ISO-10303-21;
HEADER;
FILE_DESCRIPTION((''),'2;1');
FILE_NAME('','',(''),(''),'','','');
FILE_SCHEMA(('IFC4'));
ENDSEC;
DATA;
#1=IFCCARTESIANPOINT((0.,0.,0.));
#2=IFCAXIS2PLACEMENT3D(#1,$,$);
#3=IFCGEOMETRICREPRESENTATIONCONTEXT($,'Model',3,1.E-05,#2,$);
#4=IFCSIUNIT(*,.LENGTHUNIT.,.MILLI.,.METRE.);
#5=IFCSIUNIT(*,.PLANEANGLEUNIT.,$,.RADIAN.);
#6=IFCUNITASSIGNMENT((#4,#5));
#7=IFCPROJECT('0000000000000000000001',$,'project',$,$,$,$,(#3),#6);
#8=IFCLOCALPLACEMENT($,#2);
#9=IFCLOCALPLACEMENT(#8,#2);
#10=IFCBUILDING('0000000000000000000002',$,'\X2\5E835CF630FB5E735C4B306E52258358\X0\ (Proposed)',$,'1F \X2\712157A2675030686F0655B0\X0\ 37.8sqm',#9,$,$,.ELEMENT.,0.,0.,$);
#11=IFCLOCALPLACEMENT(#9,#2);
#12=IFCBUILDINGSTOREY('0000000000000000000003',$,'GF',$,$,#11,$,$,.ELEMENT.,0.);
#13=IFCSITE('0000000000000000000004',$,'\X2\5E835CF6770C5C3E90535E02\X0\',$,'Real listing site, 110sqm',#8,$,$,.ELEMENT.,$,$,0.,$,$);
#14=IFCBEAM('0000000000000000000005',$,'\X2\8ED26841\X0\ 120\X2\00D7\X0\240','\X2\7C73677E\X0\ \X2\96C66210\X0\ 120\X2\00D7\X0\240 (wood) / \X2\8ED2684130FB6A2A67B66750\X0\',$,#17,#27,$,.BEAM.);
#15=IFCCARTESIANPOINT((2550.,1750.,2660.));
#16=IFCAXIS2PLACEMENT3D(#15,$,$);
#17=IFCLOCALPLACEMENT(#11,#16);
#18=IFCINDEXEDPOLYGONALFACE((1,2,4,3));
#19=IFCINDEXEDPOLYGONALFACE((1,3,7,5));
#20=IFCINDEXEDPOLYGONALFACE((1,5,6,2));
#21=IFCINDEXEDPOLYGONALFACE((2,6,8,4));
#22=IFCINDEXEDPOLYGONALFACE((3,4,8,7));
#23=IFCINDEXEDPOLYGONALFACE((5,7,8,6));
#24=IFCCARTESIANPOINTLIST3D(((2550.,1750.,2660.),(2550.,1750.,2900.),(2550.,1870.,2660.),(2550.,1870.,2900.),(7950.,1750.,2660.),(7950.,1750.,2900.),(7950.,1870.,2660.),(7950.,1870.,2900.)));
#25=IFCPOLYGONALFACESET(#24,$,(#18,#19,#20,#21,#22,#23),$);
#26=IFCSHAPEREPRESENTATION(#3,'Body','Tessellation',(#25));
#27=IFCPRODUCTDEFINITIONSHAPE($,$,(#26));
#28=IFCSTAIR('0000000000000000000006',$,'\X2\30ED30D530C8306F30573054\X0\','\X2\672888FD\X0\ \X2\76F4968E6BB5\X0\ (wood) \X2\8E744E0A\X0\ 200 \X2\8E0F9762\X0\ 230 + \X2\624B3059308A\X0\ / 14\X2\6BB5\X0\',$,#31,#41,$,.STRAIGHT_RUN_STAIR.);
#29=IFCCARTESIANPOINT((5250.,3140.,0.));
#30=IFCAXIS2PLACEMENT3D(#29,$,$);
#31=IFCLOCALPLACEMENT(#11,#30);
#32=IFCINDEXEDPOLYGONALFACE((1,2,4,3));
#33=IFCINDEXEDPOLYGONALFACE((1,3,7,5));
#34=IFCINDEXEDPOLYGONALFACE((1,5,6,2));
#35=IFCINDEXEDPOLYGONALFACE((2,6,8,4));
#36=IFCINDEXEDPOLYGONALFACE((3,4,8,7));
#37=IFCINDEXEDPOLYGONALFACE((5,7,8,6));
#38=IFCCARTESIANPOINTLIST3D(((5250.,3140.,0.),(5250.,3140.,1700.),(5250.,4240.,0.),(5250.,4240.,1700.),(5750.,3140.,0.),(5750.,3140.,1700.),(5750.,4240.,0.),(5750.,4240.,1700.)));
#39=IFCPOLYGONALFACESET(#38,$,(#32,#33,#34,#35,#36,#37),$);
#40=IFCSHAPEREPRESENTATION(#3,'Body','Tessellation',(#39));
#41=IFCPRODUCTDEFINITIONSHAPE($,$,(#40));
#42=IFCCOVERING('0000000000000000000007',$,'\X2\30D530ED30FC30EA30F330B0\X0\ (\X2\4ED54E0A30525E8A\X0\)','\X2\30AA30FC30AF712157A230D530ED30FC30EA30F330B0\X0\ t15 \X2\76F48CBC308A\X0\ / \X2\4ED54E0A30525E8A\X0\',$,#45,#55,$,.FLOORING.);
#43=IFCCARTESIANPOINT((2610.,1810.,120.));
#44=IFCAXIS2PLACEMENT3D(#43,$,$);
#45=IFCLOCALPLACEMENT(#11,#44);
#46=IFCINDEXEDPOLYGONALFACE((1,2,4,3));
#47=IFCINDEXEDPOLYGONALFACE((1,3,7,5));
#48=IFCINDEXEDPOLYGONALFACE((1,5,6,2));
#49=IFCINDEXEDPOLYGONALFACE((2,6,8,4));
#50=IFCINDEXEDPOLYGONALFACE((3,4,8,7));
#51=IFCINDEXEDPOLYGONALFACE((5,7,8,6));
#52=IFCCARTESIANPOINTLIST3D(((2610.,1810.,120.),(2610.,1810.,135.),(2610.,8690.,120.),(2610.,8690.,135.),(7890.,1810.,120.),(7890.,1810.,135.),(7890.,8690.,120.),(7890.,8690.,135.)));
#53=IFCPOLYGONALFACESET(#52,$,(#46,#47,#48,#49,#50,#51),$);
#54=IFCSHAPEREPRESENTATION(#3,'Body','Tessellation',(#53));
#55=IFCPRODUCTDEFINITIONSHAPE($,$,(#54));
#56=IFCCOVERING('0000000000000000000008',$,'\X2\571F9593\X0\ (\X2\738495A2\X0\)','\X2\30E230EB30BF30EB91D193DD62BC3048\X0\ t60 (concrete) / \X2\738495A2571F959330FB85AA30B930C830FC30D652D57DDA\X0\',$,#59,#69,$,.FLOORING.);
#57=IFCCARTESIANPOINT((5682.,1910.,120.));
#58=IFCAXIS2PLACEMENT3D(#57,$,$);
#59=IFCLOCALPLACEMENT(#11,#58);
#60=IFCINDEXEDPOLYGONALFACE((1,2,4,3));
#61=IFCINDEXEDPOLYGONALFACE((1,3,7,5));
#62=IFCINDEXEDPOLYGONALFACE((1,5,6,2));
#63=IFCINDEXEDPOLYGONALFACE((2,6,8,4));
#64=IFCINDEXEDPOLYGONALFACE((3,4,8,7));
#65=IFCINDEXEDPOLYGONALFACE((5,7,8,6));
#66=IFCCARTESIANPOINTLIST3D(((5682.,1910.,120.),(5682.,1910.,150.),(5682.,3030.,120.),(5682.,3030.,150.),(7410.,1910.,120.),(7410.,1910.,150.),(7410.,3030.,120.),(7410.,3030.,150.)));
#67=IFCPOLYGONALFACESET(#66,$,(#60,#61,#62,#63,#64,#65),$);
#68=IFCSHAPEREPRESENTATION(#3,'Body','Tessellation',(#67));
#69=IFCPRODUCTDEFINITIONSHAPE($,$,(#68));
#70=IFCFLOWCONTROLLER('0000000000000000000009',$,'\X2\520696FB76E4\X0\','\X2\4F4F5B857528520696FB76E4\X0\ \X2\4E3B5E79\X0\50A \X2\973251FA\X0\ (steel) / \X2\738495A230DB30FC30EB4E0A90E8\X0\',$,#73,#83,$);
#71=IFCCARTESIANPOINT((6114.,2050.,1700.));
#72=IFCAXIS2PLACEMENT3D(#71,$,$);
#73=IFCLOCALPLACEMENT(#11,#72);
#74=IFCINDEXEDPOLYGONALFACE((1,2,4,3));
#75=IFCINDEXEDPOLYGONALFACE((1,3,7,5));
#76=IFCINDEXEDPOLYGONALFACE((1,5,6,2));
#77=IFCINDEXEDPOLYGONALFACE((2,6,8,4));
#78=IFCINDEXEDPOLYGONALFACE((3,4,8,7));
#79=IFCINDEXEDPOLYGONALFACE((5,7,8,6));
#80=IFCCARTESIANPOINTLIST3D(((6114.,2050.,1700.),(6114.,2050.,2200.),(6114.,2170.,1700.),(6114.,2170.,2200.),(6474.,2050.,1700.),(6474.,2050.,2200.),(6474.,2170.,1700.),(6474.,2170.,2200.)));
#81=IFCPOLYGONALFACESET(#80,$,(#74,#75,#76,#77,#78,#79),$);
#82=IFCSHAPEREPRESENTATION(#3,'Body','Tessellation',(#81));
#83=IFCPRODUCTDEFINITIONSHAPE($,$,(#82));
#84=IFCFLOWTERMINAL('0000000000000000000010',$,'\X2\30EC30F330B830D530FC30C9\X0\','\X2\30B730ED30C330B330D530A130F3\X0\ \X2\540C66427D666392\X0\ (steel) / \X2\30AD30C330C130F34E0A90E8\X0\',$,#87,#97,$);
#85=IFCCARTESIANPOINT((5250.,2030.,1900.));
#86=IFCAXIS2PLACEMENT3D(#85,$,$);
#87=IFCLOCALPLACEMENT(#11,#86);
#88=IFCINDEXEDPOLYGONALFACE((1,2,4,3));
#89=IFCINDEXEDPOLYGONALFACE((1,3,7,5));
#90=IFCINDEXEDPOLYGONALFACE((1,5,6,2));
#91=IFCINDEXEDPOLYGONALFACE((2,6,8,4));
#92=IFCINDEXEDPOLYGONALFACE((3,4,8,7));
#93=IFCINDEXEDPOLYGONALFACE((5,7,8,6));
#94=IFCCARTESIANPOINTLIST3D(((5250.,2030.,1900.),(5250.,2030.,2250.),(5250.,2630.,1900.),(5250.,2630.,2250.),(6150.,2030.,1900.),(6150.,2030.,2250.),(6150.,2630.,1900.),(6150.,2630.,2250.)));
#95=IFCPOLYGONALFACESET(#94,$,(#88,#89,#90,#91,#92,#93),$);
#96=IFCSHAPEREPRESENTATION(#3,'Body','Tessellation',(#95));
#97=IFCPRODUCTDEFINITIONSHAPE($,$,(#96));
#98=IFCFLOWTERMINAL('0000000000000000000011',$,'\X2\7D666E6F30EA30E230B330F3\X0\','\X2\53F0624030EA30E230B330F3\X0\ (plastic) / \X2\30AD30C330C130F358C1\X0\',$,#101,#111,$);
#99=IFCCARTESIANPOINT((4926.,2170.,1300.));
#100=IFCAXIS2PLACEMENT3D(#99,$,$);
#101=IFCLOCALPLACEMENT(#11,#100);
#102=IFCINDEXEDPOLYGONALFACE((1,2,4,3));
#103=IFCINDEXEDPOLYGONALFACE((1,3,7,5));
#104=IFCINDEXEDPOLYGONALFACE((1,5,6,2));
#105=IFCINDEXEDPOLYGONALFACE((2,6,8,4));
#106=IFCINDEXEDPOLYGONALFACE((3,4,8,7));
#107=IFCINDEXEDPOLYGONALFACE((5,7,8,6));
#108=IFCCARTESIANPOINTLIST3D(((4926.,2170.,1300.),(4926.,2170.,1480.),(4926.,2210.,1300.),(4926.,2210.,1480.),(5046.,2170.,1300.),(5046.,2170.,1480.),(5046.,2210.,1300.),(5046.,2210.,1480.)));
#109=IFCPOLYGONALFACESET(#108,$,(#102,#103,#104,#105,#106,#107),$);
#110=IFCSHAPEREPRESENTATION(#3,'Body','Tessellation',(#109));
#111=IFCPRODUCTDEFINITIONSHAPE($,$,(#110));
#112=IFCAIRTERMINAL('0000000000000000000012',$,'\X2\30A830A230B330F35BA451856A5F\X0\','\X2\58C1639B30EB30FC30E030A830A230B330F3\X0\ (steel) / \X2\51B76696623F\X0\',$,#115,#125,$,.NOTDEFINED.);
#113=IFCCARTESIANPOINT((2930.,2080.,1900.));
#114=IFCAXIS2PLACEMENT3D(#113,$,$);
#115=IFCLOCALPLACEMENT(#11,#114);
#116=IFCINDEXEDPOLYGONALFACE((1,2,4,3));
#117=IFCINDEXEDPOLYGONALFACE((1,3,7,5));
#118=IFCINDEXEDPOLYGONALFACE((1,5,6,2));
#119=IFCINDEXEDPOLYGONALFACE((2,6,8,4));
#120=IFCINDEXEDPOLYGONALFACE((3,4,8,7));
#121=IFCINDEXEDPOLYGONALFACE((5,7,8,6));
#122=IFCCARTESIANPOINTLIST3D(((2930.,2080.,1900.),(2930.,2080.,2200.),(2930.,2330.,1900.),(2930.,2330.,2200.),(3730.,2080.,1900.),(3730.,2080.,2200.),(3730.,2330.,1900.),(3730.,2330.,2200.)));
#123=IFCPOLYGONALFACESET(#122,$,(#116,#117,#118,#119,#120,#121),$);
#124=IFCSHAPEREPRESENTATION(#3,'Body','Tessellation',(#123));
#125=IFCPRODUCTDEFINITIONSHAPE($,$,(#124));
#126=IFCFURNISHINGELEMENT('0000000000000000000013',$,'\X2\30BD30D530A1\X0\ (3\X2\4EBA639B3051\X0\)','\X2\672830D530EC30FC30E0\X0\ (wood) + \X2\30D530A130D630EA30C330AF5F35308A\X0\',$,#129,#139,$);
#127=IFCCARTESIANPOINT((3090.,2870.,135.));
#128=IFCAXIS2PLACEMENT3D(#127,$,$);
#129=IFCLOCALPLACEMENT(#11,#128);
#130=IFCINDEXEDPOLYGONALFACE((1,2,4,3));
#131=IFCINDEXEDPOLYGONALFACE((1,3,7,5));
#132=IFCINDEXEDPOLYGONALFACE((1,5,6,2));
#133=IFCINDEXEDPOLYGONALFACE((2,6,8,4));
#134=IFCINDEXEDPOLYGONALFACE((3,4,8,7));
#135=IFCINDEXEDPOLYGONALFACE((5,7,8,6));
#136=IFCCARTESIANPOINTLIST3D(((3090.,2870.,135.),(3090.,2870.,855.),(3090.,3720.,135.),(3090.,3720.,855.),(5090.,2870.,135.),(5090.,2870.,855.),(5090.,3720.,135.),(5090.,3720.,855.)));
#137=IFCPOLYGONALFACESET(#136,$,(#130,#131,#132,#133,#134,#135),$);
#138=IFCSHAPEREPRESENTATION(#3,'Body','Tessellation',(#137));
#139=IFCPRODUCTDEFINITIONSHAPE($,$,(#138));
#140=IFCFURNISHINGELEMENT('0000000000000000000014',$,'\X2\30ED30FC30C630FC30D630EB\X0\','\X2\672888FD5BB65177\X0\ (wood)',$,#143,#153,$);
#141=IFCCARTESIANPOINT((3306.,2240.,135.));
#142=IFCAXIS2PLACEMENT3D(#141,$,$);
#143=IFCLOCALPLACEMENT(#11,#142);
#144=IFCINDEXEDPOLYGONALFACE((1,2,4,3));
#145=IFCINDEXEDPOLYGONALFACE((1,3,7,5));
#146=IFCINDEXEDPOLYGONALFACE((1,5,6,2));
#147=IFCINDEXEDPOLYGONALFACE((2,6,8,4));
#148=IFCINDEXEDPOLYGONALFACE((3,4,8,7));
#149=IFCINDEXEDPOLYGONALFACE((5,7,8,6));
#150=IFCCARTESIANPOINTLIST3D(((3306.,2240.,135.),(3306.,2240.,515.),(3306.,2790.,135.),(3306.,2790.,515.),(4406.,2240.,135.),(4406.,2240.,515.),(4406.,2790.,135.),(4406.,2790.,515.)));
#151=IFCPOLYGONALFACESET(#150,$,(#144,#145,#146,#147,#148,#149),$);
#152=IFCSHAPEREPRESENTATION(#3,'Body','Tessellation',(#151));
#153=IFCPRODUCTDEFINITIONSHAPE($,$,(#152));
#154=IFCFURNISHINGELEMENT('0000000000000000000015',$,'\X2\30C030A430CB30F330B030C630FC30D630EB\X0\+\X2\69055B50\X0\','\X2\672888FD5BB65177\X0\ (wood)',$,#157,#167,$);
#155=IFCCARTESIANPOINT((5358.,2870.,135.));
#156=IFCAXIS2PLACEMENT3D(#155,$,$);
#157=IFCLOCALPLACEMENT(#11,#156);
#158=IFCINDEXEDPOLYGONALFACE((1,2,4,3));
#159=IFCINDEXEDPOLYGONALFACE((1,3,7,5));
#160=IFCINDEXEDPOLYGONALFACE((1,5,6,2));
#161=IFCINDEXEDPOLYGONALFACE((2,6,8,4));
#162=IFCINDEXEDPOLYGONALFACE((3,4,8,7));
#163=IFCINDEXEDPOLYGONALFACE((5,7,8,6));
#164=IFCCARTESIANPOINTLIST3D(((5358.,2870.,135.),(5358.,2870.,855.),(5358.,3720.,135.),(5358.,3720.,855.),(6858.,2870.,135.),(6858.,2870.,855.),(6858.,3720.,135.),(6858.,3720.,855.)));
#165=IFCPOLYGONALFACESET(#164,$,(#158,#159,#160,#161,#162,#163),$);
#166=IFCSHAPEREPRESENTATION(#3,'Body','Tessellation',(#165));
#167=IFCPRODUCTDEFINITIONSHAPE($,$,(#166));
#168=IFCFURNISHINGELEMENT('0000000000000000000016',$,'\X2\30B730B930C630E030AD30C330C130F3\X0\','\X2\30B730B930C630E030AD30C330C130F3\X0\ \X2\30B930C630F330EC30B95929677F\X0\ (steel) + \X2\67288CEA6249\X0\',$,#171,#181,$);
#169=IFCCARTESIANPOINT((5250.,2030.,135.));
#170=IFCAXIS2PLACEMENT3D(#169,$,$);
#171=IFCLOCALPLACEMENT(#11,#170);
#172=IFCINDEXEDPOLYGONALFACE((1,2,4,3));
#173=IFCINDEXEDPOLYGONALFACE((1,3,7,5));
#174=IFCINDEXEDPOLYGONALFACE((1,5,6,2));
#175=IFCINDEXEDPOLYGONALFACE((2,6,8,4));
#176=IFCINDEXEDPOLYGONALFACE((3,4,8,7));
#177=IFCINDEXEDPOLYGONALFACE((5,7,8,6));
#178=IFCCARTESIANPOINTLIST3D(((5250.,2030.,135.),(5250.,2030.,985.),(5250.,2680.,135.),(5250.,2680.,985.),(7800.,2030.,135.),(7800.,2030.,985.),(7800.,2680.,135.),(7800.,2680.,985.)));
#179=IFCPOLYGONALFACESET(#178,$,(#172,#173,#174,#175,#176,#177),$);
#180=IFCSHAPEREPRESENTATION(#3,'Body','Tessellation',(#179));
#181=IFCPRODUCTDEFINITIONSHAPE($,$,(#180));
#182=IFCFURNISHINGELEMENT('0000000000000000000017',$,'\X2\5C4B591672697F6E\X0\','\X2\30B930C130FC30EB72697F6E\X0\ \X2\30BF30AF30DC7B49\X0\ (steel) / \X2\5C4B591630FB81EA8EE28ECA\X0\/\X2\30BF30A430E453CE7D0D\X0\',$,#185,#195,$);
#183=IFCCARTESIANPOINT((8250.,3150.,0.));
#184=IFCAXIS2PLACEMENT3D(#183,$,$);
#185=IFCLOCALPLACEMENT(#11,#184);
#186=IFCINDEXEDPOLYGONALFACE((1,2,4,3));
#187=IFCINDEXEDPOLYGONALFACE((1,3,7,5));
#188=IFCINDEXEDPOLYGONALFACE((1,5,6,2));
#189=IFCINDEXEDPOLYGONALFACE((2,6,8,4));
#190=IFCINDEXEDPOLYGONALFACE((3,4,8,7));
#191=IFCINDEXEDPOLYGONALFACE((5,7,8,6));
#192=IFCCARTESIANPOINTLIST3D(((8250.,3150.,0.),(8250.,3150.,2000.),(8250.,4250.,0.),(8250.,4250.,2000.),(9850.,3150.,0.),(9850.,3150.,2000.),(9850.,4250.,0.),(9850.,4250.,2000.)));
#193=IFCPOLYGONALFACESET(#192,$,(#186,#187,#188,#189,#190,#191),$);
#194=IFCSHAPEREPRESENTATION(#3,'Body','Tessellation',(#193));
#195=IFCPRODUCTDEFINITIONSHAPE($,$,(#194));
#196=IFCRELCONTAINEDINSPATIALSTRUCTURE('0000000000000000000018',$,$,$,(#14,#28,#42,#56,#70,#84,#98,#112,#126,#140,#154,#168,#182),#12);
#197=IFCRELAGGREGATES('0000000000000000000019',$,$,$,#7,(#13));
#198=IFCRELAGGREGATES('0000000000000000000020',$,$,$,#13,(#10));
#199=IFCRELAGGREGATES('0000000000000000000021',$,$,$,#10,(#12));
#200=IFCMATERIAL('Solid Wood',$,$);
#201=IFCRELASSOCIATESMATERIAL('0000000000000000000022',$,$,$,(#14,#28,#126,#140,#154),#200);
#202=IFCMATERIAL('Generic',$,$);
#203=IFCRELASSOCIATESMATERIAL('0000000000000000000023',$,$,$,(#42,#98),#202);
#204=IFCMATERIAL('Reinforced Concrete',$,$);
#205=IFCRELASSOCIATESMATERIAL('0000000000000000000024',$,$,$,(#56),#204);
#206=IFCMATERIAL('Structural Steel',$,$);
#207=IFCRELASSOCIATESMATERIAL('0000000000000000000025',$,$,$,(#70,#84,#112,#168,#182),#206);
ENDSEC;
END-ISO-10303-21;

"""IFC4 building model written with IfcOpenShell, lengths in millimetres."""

from ifc_helpers import new_model, si_unit, frame, frame_2d, origin, place, context, project, spatial, rectangle, extrude, material, element, save


model = new_model("IFC4")

# Units and contexts
model_context = context("Model", 3, precision=1e-05, world=origin())
ifc_project = project(units=[si_unit("LENGTHUNIT", "METRE", prefix="MILLI"), si_unit("PLANEANGLEUNIT", "RADIAN")], contexts=[model_context])

# Site, building, storey
site_placement = place(None, origin())
site = spatial("IfcSite", under=ifc_project, at=site_placement, Name="広島県尾道市", ObjectType="Real listing site, 110sqm", CompositionType="ELEMENT", RefElevation=0.0)
building_placement = place(site_placement, origin())
building = spatial("IfcBuilding", under=site, at=building_placement, Name="広島・平屋の別荘 (Proposed)", ObjectType="1F 無垢材と漆喰 37.8sqm", CompositionType="ELEMENT", ElevationOfRefHeight=0.0, ElevationOfTerrain=0.0)
storey_placement = place(building_placement, origin())
storey = spatial("IfcBuildingStorey", under=building, at=storey_placement, Name="GF", CompositionType="ELEMENT", Elevation=0.0)

# Beam
ifc_material_1 = material(Name="Solid Wood")
beam_1_placement = place(storey_placement, frame((2550.0, 1750.0, 2660.0)))
element("IfcBeam", 1, at=beam_1_placement, inside=storey, material=ifc_material_1, Name="軒桁 120×240", Description="米松 集成 120×240 (wood) / 軒桁・横架材", PredefinedType="BEAM", context=model_context, shape_type="SweptSolid", body=[
    extrude(rectangle(XDim=5400.0, YDim=120.0, at=frame_2d((2700.0, 60.0))), frame((2550.0, 1750.0, 2660.0)), (0.0, 0.0, 1.0), 240.0),
])

# Stair
stair_placement = place(storey_placement, frame((5250.0, 3140.0, 0.0)))
element("IfcStair", 2, at=stair_placement, inside=storey, material=ifc_material_1, Name="ロフトはしご", Description="木製 直階段 (wood) 蹴上 200 踏面 230 + 手すり / 14段", PredefinedType="STRAIGHT_RUN_STAIR", context=model_context, shape_type="SweptSolid", body=[
    extrude(rectangle(XDim=500.0, YDim=1100.0, at=frame_2d((250.0, 550.0))), frame((5250.0, 3140.0, 0.0)), (0.0, 0.0, 1.0), 1700.0),
])

# Coverings
ifc_material_2 = material(Name="Generic")
covering_1_placement = place(storey_placement, frame((2610.0, 1810.0, 120.0)))
element("IfcCovering", 3, at=covering_1_placement, inside=storey, material=ifc_material_2, Name="フローリング (仕上げ床)", Description="オーク無垢フローリング t15 直貼り / 仕上げ床", PredefinedType="FLOORING", context=model_context, shape_type="SweptSolid", body=[
    extrude(rectangle(XDim=5280.0, YDim=6880.0, at=frame_2d((2640.0, 3440.0))), frame((2610.0, 1810.0, 120.0)), (0.0, 0.0, 1.0), 15.0),
])
ifc_material_3 = material(Name="Reinforced Concrete")
covering_2_placement = place(storey_placement, frame((5682.0, 1910.0, 120.0)))
element("IfcCovering", 4, at=covering_2_placement, inside=storey, material=ifc_material_3, Name="土間 (玄関)", Description="モルタル金鏝押え t60 (concrete) / 玄関土間・薪ストーブ動線", PredefinedType="FLOORING", context=model_context, shape_type="SweptSolid", body=[
    extrude(rectangle(XDim=1728.0, YDim=1120.0, at=frame_2d((864.0, 560.0))), frame((5682.0, 1910.0, 120.0)), (0.0, 0.0, 1.0), 30.0),
])

# Flow controller
ifc_material_4 = material(Name="Structural Steel")
flow_controller_placement = place(storey_placement, frame((6114.0, 2050.0, 1700.0)))
element("IfcFlowController", 5, at=flow_controller_placement, inside=storey, material=ifc_material_4, Name="分電盤", Description="住宅用分電盤 主幹50A 露出 (steel) / 玄関ホール上部", context=model_context, shape_type="SweptSolid", body=[
    extrude(rectangle(XDim=360.0, YDim=120.0, at=frame_2d((180.0, 60.0))), frame((6114.0, 2050.0, 1700.0)), (0.0, 0.0, 1.0), 500.0),
])

# Flow terminals
flow_terminal_1_placement = place(storey_placement, frame((5250.0, 2030.0, 1900.0)))
element("IfcFlowTerminal", 6, at=flow_terminal_1_placement, inside=storey, material=ifc_material_4, Name="レンジフード", Description="シロッコファン 同時給排 (steel) / キッチン上部", context=model_context, shape_type="SweptSolid", body=[
    extrude(rectangle(XDim=900.0, YDim=600.0, at=frame_2d((450.0, 300.0))), frame((5250.0, 2030.0, 1900.0)), (0.0, 0.0, 1.0), 350.0),
])
flow_terminal_2_placement = place(storey_placement, frame((4926.0, 2170.0, 1300.0)))
element("IfcFlowTerminal", 7, at=flow_terminal_2_placement, inside=storey, material=ifc_material_2, Name="給湯リモコン", Description="台所リモコン (plastic) / キッチン壁", context=model_context, shape_type="SweptSolid", body=[
    extrude(rectangle(XDim=120.0, YDim=40.0, at=frame_2d((60.0, 20.0))), frame((4926.0, 2170.0, 1300.0)), (0.0, 0.0, 1.0), 180.0),
])

# Air terminal
air_terminal_placement = place(storey_placement, frame((2930.0, 2080.0, 1900.0)))
element("IfcAirTerminal", 8, at=air_terminal_placement, inside=storey, material=ifc_material_4, Name="エアコン室内機", Description="壁掛ルームエアコン (steel) / 冷暖房", PredefinedType="NOTDEFINED", context=model_context, shape_type="SweptSolid", body=[
    extrude(rectangle(XDim=800.0, YDim=250.0, at=frame_2d((400.0, 125.0))), frame((2930.0, 2080.0, 1900.0)), (0.0, 0.0, 1.0), 300.0),
])

# Furnishing elements
furnishing_1_placement = place(storey_placement, frame((3090.0, 2870.0, 135.0)))
element("IfcFurnishingElement", 9, at=furnishing_1_placement, inside=storey, material=ifc_material_1, Name="ソファ (3人掛け)", Description="木フレーム (wood) + ファブリック張り", context=model_context, shape_type="SweptSolid", body=[
    extrude(rectangle(XDim=2000.0, YDim=850.0, at=frame_2d((1000.0, 425.0))), frame((3090.0, 2870.0, 135.0)), (0.0, 0.0, 1.0), 720.0),
])
furnishing_2_placement = place(storey_placement, frame((3306.0, 2240.0, 135.0)))
element("IfcFurnishingElement", 10, at=furnishing_2_placement, inside=storey, material=ifc_material_1, Name="ローテーブル", Description="木製家具 (wood)", context=model_context, shape_type="SweptSolid", body=[
    extrude(rectangle(XDim=1100.0, YDim=550.0, at=frame_2d((550.0, 275.0))), frame((3306.0, 2240.0, 135.0)), (0.0, 0.0, 1.0), 380.0),
])
furnishing_3_placement = place(storey_placement, frame((5358.0, 2870.0, 135.0)))
element("IfcFurnishingElement", 11, at=furnishing_3_placement, inside=storey, material=ifc_material_1, Name="ダイニングテーブル+椅子", Description="木製家具 (wood)", context=model_context, shape_type="SweptSolid", body=[
    extrude(rectangle(XDim=1500.0, YDim=850.0, at=frame_2d((750.0, 425.0))), frame((5358.0, 2870.0, 135.0)), (0.0, 0.0, 1.0), 720.0),
])
furnishing_4_placement = place(storey_placement, frame((5250.0, 2030.0, 135.0)))
element("IfcFurnishingElement", 12, at=furnishing_4_placement, inside=storey, material=ifc_material_4, Name="システムキッチン", Description="システムキッチン ステンレス天板 (steel) + 木質扉", context=model_context, shape_type="SweptSolid", body=[
    extrude(rectangle(XDim=2550.0, YDim=650.0, at=frame_2d((1275.0, 325.0))), frame((5250.0, 2030.0, 135.0)), (0.0, 0.0, 1.0), 850.0),
])
furnishing_5_placement = place(storey_placement, frame((8250.0, 3150.0, 0.0)))
element("IfcFurnishingElement", 13, at=furnishing_5_placement, inside=storey, material=ifc_material_4, Name="屋外物置", Description="スチール物置 タクボ等 (steel) / 屋外・自転車/タイヤ収納", context=model_context, shape_type="SweptSolid", body=[
    extrude(rectangle(XDim=1600.0, YDim=1100.0, at=frame_2d((800.0, 550.0))), frame((8250.0, 3150.0, 0.0)), (0.0, 0.0, 1.0), 2000.0),
])

save(model, "model.ifc")
